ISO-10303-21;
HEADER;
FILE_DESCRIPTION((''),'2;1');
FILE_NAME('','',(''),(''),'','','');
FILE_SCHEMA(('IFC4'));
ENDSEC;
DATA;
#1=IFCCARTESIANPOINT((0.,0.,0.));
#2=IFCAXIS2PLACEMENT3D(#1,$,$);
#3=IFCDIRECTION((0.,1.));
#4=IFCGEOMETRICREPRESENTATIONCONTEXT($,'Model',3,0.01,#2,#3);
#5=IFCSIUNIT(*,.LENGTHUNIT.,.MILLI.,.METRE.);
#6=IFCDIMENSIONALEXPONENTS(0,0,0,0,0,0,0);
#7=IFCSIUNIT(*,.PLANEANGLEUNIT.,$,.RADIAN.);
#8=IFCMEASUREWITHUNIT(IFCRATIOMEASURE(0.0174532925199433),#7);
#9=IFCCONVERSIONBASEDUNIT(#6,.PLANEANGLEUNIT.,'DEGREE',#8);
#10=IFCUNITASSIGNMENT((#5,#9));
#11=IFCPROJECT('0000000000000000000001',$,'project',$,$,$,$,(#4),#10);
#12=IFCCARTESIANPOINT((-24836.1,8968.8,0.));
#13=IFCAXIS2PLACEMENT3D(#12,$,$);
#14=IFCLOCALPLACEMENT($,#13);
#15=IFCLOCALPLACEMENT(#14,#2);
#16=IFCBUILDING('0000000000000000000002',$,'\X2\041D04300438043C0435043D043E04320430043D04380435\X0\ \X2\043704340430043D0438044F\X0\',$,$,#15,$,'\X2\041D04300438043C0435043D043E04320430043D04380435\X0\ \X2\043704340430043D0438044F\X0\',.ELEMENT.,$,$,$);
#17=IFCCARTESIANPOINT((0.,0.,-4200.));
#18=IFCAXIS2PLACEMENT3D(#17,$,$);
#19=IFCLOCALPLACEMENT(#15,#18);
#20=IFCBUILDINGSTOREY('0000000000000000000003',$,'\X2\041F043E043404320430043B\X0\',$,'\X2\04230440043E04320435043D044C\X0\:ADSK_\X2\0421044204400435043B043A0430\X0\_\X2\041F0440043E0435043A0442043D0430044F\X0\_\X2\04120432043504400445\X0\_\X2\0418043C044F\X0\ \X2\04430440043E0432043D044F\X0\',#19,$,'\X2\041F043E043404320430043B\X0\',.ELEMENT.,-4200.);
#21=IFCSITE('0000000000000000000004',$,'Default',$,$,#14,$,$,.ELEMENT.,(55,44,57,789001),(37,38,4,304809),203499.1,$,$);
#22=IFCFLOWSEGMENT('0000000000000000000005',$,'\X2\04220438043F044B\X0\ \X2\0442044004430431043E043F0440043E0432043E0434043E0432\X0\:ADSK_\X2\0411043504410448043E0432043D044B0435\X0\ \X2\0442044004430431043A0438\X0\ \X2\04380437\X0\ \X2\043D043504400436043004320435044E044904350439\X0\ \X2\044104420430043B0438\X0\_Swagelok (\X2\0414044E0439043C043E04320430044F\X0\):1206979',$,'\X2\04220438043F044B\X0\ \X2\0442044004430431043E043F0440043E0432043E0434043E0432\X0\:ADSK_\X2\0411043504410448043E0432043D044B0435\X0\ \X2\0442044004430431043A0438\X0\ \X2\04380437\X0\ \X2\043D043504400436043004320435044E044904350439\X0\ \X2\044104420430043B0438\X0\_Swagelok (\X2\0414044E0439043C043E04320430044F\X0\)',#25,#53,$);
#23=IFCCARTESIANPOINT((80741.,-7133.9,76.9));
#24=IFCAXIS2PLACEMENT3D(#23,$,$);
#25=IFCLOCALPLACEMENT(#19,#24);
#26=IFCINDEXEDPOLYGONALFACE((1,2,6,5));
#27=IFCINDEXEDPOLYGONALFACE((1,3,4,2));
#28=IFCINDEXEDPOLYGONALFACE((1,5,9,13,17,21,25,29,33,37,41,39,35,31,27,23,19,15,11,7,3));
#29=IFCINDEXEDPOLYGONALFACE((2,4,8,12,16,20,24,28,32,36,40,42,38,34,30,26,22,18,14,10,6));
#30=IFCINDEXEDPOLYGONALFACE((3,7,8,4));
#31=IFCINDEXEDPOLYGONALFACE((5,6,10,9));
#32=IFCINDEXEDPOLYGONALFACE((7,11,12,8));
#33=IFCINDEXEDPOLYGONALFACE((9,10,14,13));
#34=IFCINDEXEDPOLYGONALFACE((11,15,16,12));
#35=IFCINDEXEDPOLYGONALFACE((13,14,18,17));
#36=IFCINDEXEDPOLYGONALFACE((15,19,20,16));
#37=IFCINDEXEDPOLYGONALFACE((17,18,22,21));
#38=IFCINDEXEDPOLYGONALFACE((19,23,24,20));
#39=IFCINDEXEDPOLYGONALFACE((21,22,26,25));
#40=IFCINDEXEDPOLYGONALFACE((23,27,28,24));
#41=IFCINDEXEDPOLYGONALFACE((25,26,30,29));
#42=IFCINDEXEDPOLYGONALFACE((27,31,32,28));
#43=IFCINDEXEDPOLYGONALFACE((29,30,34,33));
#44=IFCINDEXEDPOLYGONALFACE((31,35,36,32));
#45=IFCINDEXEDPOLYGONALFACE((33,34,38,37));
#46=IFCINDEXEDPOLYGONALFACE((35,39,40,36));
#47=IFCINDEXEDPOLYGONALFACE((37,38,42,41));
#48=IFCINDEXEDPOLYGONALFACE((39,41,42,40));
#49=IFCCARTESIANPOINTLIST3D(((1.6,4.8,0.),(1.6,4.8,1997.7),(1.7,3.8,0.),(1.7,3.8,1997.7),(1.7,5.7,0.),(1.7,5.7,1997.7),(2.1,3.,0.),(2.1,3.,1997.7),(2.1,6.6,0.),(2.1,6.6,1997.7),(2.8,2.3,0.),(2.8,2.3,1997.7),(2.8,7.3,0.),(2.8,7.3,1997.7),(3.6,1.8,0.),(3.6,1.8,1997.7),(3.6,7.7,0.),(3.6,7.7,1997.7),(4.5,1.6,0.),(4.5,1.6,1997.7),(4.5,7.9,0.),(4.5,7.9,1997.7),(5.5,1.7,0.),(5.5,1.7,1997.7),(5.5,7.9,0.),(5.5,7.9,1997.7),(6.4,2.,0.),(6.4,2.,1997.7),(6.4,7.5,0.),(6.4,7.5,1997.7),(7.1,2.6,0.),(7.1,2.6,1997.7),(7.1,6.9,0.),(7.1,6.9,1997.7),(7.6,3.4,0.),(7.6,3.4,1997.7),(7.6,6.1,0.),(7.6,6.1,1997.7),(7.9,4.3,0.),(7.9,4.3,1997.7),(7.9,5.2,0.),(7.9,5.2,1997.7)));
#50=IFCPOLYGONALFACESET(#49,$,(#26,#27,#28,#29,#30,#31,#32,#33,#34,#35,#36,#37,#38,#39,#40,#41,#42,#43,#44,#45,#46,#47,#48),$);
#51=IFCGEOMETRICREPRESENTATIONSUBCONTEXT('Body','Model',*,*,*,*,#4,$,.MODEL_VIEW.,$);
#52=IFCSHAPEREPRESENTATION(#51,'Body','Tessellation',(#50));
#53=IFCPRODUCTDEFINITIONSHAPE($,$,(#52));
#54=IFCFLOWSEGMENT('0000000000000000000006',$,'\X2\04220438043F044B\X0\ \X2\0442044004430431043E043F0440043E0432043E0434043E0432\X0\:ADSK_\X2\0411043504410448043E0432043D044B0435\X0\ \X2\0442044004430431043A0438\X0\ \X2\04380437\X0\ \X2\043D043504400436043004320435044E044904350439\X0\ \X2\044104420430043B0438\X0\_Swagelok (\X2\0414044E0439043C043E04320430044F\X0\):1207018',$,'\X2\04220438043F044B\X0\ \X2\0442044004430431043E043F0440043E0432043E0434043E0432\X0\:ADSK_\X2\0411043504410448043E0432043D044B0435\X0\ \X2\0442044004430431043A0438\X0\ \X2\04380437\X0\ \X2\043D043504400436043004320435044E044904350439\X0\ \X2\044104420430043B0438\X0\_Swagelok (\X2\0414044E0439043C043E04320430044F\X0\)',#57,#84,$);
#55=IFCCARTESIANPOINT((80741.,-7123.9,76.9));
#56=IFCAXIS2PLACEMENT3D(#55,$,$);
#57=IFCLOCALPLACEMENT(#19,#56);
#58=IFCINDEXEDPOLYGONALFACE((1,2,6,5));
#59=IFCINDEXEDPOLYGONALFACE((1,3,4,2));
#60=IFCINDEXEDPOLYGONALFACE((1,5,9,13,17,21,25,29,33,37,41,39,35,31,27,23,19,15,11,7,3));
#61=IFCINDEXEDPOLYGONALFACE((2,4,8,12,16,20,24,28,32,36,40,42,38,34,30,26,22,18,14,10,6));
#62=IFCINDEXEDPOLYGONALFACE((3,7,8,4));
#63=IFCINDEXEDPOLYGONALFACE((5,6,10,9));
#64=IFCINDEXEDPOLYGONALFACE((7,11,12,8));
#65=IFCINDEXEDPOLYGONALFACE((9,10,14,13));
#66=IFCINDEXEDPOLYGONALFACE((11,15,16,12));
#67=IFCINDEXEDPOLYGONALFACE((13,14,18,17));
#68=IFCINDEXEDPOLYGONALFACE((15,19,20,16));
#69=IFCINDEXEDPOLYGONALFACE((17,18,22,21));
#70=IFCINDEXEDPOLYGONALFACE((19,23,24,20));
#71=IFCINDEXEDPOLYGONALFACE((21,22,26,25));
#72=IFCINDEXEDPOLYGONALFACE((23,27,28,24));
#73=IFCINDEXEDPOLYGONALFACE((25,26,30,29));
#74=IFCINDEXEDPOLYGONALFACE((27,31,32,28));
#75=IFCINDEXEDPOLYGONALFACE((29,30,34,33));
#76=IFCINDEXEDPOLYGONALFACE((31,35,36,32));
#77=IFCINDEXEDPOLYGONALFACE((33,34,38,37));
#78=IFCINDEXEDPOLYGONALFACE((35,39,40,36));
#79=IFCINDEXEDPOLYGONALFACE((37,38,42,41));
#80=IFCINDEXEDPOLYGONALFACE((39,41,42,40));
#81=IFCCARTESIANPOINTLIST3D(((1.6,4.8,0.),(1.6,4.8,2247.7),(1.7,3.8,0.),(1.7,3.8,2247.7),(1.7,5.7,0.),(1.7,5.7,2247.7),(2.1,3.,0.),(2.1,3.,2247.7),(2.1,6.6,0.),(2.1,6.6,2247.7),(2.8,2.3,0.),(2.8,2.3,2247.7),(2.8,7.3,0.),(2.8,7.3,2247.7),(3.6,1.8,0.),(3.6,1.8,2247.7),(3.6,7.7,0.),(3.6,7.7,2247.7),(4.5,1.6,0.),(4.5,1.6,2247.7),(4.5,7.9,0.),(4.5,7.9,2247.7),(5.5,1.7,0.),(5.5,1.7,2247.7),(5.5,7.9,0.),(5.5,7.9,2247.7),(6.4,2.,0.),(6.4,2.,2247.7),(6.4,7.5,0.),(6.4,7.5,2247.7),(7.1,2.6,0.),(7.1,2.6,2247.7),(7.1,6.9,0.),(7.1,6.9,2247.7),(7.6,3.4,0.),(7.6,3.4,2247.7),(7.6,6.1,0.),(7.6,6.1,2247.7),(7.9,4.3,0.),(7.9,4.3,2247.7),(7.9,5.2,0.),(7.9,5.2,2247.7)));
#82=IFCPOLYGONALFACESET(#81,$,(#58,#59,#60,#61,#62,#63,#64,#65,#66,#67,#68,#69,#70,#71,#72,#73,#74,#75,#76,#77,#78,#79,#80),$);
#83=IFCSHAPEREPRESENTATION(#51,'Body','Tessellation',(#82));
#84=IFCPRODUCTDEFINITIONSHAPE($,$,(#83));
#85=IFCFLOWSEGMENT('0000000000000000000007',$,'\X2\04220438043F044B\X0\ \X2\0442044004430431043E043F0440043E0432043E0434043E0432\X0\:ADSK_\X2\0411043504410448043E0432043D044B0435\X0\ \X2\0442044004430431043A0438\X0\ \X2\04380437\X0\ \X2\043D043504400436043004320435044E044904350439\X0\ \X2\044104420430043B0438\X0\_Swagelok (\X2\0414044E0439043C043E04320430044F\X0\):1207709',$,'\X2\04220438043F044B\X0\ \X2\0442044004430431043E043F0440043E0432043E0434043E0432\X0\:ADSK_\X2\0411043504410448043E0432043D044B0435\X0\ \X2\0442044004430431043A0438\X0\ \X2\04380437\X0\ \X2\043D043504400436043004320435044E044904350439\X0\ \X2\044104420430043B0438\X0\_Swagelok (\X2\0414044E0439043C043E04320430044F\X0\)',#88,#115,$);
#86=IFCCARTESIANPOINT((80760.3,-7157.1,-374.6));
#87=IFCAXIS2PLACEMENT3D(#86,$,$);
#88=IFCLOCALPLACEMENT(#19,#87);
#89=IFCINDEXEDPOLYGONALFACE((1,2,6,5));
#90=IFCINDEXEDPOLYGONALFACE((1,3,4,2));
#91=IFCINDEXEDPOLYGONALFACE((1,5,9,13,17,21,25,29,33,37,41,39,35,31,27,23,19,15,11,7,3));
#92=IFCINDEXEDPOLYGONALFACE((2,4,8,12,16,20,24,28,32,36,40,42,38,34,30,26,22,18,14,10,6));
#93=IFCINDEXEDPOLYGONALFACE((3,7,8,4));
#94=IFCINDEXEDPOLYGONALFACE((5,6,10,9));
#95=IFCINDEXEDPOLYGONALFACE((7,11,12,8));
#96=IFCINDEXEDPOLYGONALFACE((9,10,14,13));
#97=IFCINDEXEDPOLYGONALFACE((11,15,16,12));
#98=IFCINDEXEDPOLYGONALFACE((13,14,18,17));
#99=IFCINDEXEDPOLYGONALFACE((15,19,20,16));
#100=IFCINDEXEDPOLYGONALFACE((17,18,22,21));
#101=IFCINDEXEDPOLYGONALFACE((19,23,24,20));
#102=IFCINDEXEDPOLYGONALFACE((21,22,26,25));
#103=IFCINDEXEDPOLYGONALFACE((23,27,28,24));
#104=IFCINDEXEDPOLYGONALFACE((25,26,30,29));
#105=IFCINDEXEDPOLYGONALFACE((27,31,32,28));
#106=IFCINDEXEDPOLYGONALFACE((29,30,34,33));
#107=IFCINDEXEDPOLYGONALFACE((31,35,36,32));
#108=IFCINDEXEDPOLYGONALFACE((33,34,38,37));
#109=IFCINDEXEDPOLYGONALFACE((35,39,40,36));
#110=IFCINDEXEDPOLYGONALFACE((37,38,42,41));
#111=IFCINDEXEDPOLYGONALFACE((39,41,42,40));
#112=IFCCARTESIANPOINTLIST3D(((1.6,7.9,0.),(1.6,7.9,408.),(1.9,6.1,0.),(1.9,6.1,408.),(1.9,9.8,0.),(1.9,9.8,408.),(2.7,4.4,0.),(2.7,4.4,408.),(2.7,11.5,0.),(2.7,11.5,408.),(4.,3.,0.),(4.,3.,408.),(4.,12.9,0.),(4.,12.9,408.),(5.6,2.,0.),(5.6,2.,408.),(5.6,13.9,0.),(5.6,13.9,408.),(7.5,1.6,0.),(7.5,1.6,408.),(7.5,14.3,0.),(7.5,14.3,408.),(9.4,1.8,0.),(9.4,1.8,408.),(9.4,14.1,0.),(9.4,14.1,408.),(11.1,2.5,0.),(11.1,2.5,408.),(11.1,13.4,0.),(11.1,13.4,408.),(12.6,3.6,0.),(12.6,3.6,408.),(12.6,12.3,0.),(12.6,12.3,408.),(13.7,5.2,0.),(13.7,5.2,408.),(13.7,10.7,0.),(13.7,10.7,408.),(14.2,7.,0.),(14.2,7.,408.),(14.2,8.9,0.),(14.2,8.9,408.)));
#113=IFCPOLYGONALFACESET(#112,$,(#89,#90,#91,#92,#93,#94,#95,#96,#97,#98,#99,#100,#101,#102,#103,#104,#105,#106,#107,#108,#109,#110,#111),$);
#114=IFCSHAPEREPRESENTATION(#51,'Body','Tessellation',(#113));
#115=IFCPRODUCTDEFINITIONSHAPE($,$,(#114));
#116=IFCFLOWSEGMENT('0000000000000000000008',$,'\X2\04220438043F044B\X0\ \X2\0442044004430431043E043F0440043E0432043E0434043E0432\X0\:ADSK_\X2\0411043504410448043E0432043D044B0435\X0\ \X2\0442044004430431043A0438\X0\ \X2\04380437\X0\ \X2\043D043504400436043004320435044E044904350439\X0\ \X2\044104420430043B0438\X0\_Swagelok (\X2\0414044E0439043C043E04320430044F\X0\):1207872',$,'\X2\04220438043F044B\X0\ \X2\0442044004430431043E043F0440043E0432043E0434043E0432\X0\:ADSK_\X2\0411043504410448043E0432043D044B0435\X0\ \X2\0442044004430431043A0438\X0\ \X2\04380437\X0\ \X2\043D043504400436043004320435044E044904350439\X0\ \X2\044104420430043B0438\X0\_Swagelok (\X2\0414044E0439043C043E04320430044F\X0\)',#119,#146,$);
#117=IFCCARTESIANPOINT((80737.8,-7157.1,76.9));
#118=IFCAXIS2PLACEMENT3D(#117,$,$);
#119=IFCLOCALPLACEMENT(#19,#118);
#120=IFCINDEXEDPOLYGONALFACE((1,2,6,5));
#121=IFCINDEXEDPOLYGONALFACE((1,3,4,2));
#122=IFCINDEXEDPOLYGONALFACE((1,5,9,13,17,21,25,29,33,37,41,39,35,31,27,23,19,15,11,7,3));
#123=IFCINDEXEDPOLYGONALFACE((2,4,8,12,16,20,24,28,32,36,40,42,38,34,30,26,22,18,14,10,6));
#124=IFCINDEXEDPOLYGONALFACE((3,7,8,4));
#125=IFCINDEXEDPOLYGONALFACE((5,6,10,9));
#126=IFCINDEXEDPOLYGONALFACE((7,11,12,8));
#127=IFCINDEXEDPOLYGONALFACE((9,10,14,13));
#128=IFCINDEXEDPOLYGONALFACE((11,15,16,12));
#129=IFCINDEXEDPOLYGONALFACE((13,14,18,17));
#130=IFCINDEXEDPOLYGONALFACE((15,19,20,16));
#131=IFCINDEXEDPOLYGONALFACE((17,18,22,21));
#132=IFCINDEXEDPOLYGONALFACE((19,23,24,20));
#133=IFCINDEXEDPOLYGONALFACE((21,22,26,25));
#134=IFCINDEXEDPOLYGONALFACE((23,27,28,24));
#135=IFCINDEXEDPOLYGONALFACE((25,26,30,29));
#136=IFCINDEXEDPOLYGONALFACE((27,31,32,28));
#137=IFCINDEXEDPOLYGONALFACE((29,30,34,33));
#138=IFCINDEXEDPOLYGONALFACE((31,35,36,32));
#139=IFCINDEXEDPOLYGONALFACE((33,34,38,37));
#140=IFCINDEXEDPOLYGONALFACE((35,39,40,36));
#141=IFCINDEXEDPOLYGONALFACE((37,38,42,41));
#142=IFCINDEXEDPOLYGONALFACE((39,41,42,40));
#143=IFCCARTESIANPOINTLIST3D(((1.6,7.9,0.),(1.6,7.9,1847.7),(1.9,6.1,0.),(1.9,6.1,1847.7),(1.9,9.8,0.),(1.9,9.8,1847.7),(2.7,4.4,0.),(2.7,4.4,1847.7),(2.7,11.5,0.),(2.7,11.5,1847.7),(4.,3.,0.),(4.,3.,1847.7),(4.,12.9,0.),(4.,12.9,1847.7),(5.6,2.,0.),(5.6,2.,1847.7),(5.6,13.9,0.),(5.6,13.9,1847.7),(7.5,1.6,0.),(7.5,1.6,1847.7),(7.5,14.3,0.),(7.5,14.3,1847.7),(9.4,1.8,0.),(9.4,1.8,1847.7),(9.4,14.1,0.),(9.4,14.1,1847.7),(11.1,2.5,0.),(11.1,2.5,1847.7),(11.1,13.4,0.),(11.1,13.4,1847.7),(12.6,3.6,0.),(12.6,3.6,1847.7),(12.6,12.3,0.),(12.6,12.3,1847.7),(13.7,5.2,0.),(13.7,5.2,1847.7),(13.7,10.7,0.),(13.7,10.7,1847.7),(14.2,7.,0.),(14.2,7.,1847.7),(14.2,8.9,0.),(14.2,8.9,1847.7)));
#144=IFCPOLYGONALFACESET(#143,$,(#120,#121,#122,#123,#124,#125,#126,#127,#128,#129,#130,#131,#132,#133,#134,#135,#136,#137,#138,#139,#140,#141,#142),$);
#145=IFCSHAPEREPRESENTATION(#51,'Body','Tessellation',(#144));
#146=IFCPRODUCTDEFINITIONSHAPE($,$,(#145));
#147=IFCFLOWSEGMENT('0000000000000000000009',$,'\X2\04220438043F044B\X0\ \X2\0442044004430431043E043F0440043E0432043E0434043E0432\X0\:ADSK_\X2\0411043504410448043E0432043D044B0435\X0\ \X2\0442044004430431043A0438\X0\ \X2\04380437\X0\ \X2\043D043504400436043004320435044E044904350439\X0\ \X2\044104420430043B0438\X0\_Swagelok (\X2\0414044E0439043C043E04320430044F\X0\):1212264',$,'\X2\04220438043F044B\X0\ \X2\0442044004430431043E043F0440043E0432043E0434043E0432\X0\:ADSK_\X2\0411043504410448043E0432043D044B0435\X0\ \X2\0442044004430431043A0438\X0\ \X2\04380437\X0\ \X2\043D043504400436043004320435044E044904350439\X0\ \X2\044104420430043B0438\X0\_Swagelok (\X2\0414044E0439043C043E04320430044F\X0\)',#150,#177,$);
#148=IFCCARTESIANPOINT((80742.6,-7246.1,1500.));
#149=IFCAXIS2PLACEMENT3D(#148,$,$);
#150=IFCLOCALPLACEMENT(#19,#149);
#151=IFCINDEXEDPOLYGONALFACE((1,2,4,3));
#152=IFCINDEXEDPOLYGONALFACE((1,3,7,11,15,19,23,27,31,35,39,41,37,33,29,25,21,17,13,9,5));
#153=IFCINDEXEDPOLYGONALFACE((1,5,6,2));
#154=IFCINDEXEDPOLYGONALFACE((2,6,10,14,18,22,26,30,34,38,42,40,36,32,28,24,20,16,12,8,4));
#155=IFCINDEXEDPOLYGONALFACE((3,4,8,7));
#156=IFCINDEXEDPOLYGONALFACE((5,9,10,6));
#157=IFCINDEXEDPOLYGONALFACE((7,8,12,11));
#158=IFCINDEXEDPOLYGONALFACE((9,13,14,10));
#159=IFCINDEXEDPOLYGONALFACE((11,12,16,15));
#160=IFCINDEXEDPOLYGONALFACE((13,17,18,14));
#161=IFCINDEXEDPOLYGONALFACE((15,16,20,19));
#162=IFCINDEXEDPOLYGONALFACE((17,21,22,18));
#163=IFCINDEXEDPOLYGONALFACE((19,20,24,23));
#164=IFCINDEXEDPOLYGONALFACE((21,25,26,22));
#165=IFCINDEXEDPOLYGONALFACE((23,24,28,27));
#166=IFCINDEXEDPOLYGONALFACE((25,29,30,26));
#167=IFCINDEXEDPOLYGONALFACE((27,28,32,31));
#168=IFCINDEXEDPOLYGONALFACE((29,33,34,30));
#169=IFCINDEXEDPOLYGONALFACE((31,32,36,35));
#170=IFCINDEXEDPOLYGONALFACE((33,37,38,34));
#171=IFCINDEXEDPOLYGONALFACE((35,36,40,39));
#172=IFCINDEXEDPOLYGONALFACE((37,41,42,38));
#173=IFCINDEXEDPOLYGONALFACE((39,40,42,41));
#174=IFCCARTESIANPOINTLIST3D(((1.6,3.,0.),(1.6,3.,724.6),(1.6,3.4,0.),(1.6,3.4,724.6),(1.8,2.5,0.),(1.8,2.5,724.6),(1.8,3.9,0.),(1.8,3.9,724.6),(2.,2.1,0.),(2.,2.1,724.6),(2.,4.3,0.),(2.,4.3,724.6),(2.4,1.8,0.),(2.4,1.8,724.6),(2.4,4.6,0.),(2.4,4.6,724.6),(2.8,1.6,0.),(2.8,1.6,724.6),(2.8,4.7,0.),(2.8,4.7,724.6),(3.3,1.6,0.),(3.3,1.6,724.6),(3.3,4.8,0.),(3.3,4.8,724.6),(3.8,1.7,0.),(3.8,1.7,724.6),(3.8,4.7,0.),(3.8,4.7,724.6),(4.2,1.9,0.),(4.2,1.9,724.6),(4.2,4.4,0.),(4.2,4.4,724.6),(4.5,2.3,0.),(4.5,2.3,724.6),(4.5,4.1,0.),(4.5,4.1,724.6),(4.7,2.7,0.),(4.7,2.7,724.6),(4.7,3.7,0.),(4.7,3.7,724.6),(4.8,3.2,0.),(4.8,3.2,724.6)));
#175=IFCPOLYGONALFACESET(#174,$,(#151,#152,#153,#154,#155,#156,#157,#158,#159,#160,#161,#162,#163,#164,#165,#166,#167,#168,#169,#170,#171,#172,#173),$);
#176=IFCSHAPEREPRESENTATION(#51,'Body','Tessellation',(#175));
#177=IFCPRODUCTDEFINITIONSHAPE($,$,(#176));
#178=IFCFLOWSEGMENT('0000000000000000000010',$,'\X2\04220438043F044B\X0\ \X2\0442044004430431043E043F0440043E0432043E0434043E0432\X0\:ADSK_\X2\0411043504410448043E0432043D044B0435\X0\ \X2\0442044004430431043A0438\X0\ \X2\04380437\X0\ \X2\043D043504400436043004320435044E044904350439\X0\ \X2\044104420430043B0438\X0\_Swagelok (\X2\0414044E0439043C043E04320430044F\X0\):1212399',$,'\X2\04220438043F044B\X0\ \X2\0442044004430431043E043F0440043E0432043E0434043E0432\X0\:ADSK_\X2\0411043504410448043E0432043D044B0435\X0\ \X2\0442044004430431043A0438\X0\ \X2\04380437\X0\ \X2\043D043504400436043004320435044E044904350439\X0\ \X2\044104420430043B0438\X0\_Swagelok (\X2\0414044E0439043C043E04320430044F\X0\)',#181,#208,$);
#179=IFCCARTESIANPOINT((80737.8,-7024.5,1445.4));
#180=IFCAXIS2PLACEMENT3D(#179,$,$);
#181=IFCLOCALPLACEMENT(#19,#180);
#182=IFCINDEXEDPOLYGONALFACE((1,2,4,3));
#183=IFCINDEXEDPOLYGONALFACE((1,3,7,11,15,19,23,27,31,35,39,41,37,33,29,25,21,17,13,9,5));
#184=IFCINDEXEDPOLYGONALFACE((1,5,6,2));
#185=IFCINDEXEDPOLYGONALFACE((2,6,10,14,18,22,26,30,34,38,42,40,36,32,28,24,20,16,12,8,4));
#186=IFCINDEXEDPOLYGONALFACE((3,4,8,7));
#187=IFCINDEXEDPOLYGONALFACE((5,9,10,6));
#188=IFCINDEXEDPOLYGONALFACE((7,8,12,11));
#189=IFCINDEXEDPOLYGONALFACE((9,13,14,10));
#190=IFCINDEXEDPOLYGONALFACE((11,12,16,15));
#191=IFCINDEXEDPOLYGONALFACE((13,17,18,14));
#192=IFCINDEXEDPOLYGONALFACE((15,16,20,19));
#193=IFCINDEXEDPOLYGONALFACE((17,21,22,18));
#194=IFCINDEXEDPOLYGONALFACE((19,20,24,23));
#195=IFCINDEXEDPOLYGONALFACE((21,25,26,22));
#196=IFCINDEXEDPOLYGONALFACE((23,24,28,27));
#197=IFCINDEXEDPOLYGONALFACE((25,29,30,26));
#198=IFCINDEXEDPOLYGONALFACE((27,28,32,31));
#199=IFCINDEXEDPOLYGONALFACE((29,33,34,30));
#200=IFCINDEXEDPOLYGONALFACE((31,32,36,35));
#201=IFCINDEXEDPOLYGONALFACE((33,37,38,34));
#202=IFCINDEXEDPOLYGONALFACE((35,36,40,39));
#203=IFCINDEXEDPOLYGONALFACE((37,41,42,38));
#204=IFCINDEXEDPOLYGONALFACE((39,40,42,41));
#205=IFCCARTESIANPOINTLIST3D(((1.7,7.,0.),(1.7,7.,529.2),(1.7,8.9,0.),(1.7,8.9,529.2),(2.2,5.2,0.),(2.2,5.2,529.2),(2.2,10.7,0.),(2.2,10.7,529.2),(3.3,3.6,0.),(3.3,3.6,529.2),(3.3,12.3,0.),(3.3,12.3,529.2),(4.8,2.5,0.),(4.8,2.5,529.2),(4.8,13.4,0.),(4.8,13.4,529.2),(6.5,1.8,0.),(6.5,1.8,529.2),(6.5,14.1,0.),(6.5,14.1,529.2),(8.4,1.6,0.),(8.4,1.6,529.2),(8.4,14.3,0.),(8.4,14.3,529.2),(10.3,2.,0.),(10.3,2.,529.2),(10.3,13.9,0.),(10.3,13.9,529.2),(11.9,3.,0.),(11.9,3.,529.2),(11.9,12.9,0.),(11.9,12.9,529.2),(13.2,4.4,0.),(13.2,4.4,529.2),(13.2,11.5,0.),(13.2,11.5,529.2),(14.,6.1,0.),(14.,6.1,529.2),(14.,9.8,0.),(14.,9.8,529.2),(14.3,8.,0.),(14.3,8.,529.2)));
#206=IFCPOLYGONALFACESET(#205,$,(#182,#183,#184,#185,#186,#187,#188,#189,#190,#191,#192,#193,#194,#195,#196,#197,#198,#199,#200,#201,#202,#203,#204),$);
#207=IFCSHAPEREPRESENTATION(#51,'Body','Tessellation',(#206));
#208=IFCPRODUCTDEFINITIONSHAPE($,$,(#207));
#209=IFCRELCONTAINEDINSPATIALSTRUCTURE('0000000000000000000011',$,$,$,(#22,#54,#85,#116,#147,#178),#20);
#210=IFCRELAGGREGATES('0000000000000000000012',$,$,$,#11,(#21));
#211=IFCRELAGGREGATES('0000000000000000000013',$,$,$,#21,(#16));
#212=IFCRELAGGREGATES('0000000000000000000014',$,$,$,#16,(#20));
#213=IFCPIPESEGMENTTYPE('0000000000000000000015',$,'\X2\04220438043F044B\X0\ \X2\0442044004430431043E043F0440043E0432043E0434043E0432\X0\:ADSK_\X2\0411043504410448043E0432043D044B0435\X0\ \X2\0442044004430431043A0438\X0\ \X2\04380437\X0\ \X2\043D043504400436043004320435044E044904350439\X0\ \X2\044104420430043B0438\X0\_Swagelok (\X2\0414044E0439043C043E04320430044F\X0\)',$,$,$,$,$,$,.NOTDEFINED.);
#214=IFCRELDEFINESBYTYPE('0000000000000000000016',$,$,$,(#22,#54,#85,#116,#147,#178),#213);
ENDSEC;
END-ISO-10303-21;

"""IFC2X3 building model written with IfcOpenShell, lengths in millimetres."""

from ifc_helpers import new_model, entity, si_unit, converted_unit, direction, frame, origin, origin_2d_with_axis, place, context, subcontext, project, spatial, circle, extrude, type_object, element, save


model = new_model("IFC2X3")

# Units and contexts
model_context = context("Model", 3, precision=0.01, world=origin(), true_north=direction((0.0, 1.0)))
body_context = subcontext(model_context, "Body", "Model", "MODEL_VIEW")
ifc_project = project(units=[si_unit("LENGTHUNIT", "METRE", prefix="MILLI"), converted_unit("PLANEANGLEUNIT", "DEGREE", entity("IfcRatioMeasure", 0.0174532925199433), si_unit("PLANEANGLEUNIT", "RADIAN"), dimensions=[0, 0, 0, 0, 0, 0, 0])], contexts=[model_context])

# Site, building, storey
site_placement = place(None, frame((-24836.1, 8968.8, 0.0)))
site = spatial("IfcSite", under=ifc_project, at=site_placement, Name="Default", CompositionType="ELEMENT", RefLatitude=(55, 44, 57, 789001), RefLongitude=(37, 38, 4, 304809), RefElevation=203499.1)
building_placement = place(site_placement, origin())
building = spatial("IfcBuilding", under=site, at=building_placement, Name="Наименование здания", LongName="Наименование здания", CompositionType="ELEMENT")
storey_placement = place(building_placement, frame((0.0, 0.0, -4200.0)))
storey = spatial("IfcBuildingStorey", under=building, at=storey_placement, Name="Подвал", ObjectType="Уровень:ADSK_Стрелка_Проектная_Вверх_Имя уровня", LongName="Подвал", CompositionType="ELEMENT", Elevation=-4200.0)

# Flow segments
pipe_segment_type_1 = type_object("IfcPipeSegmentType", Name="Типы трубопроводов:ADSK_Бесшовные трубки из нержавеющей стали_Swagelok (Дюймовая)", PredefinedType="NOTDEFINED")
flow_segment_1_placement = place(storey_placement, frame((80741.0, -7133.9, 76.9)))
element("IfcFlowSegment", 1, at=flow_segment_1_placement, inside=storey, type_object=pipe_segment_type_1, Name="Типы трубопроводов:ADSK_Бесшовные трубки из нержавеющей стали_Swagelok (Дюймовая):1206979", ObjectType="Типы трубопроводов:ADSK_Бесшовные трубки из нержавеющей стали_Swagelok (Дюймовая)", context=body_context, shape_type="SweptSolid", body=[
    extrude(circle(Radius=3.2, at=origin_2d_with_axis()), frame((4.8, 4.8, 0.0), z_axis=(0.0, 0.0, 1.0), x_axis=(-1.0, 0.0, 0.0)), (0.0, 0.0, 1.0), 1997.7),
])
flow_segment_2_placement = place(storey_placement, frame((80741.0, -7123.9, 76.9)))
element("IfcFlowSegment", 2, at=flow_segment_2_placement, inside=storey, type_object=pipe_segment_type_1, Name="Типы трубопроводов:ADSK_Бесшовные трубки из нержавеющей стали_Swagelok (Дюймовая):1207018", ObjectType="Типы трубопроводов:ADSK_Бесшовные трубки из нержавеющей стали_Swagelok (Дюймовая)", context=body_context, shape_type="SweptSolid", body=[
    extrude(circle(Radius=3.2, at=origin_2d_with_axis()), frame((4.8, 4.8, 0.0), z_axis=(0.0, 0.0, 1.0), x_axis=(-1.0, 0.0, 0.0)), (0.0, 0.0, 1.0), 2247.7),
])
flow_segment_3_placement = place(storey_placement, frame((80760.3, -7157.1, -374.6)))
element("IfcFlowSegment", 3, at=flow_segment_3_placement, inside=storey, type_object=pipe_segment_type_1, Name="Типы трубопроводов:ADSK_Бесшовные трубки из нержавеющей стали_Swagelok (Дюймовая):1207709", ObjectType="Типы трубопроводов:ADSK_Бесшовные трубки из нержавеющей стали_Swagelok (Дюймовая)", context=body_context, shape_type="SweptSolid", body=[
    extrude(circle(Radius=6.3, at=origin_2d_with_axis()), frame((8.0, 8.0, 0.0), z_axis=(0.0, 0.0, 1.0), x_axis=(-1.0, 0.0, 0.0)), (0.0, 0.0, 1.0), 408.0),
])
flow_segment_4_placement = place(storey_placement, frame((80737.8, -7157.1, 76.9)))
element("IfcFlowSegment", 4, at=flow_segment_4_placement, inside=storey, type_object=pipe_segment_type_1, Name="Типы трубопроводов:ADSK_Бесшовные трубки из нержавеющей стали_Swagelok (Дюймовая):1207872", ObjectType="Типы трубопроводов:ADSK_Бесшовные трубки из нержавеющей стали_Swagelok (Дюймовая)", context=body_context, shape_type="SweptSolid", body=[
    extrude(circle(Radius=6.3, at=origin_2d_with_axis()), frame((8.0, 8.0, 0.0), z_axis=(0.0, 0.0, 1.0), x_axis=(-1.0, 0.0, 0.0)), (0.0, 0.0, 1.0), 1847.7),
])
flow_segment_5_placement = place(storey_placement, frame((80742.6, -7246.1, 1500.0)))
element("IfcFlowSegment", 5, at=flow_segment_5_placement, inside=storey, type_object=pipe_segment_type_1, Name="Типы трубопроводов:ADSK_Бесшовные трубки из нержавеющей стали_Swagelok (Дюймовая):1212264", ObjectType="Типы трубопроводов:ADSK_Бесшовные трубки из нержавеющей стали_Swagelok (Дюймовая)", context=body_context, shape_type="SweptSolid", body=[
    extrude(circle(Radius=1.6, at=origin_2d_with_axis()), frame((3.2, 3.2, 0.0)), (0.0, 0.0, 1.0), 724.6),
])
flow_segment_6_placement = place(storey_placement, frame((80737.8, -7024.5, 1445.4)))
element("IfcFlowSegment", 6, at=flow_segment_6_placement, inside=storey, type_object=pipe_segment_type_1, Name="Типы трубопроводов:ADSK_Бесшовные трубки из нержавеющей стали_Swagelok (Дюймовая):1212399", ObjectType="Типы трубопроводов:ADSK_Бесшовные трубки из нержавеющей стали_Swagelok (Дюймовая)", context=body_context, shape_type="SweptSolid", body=[
    extrude(circle(Radius=6.3, at=origin_2d_with_axis()), frame((8.0, 8.0, 0.0)), (0.0, 0.0, 1.0), 529.2),
])

save(model, "model.ifc")
